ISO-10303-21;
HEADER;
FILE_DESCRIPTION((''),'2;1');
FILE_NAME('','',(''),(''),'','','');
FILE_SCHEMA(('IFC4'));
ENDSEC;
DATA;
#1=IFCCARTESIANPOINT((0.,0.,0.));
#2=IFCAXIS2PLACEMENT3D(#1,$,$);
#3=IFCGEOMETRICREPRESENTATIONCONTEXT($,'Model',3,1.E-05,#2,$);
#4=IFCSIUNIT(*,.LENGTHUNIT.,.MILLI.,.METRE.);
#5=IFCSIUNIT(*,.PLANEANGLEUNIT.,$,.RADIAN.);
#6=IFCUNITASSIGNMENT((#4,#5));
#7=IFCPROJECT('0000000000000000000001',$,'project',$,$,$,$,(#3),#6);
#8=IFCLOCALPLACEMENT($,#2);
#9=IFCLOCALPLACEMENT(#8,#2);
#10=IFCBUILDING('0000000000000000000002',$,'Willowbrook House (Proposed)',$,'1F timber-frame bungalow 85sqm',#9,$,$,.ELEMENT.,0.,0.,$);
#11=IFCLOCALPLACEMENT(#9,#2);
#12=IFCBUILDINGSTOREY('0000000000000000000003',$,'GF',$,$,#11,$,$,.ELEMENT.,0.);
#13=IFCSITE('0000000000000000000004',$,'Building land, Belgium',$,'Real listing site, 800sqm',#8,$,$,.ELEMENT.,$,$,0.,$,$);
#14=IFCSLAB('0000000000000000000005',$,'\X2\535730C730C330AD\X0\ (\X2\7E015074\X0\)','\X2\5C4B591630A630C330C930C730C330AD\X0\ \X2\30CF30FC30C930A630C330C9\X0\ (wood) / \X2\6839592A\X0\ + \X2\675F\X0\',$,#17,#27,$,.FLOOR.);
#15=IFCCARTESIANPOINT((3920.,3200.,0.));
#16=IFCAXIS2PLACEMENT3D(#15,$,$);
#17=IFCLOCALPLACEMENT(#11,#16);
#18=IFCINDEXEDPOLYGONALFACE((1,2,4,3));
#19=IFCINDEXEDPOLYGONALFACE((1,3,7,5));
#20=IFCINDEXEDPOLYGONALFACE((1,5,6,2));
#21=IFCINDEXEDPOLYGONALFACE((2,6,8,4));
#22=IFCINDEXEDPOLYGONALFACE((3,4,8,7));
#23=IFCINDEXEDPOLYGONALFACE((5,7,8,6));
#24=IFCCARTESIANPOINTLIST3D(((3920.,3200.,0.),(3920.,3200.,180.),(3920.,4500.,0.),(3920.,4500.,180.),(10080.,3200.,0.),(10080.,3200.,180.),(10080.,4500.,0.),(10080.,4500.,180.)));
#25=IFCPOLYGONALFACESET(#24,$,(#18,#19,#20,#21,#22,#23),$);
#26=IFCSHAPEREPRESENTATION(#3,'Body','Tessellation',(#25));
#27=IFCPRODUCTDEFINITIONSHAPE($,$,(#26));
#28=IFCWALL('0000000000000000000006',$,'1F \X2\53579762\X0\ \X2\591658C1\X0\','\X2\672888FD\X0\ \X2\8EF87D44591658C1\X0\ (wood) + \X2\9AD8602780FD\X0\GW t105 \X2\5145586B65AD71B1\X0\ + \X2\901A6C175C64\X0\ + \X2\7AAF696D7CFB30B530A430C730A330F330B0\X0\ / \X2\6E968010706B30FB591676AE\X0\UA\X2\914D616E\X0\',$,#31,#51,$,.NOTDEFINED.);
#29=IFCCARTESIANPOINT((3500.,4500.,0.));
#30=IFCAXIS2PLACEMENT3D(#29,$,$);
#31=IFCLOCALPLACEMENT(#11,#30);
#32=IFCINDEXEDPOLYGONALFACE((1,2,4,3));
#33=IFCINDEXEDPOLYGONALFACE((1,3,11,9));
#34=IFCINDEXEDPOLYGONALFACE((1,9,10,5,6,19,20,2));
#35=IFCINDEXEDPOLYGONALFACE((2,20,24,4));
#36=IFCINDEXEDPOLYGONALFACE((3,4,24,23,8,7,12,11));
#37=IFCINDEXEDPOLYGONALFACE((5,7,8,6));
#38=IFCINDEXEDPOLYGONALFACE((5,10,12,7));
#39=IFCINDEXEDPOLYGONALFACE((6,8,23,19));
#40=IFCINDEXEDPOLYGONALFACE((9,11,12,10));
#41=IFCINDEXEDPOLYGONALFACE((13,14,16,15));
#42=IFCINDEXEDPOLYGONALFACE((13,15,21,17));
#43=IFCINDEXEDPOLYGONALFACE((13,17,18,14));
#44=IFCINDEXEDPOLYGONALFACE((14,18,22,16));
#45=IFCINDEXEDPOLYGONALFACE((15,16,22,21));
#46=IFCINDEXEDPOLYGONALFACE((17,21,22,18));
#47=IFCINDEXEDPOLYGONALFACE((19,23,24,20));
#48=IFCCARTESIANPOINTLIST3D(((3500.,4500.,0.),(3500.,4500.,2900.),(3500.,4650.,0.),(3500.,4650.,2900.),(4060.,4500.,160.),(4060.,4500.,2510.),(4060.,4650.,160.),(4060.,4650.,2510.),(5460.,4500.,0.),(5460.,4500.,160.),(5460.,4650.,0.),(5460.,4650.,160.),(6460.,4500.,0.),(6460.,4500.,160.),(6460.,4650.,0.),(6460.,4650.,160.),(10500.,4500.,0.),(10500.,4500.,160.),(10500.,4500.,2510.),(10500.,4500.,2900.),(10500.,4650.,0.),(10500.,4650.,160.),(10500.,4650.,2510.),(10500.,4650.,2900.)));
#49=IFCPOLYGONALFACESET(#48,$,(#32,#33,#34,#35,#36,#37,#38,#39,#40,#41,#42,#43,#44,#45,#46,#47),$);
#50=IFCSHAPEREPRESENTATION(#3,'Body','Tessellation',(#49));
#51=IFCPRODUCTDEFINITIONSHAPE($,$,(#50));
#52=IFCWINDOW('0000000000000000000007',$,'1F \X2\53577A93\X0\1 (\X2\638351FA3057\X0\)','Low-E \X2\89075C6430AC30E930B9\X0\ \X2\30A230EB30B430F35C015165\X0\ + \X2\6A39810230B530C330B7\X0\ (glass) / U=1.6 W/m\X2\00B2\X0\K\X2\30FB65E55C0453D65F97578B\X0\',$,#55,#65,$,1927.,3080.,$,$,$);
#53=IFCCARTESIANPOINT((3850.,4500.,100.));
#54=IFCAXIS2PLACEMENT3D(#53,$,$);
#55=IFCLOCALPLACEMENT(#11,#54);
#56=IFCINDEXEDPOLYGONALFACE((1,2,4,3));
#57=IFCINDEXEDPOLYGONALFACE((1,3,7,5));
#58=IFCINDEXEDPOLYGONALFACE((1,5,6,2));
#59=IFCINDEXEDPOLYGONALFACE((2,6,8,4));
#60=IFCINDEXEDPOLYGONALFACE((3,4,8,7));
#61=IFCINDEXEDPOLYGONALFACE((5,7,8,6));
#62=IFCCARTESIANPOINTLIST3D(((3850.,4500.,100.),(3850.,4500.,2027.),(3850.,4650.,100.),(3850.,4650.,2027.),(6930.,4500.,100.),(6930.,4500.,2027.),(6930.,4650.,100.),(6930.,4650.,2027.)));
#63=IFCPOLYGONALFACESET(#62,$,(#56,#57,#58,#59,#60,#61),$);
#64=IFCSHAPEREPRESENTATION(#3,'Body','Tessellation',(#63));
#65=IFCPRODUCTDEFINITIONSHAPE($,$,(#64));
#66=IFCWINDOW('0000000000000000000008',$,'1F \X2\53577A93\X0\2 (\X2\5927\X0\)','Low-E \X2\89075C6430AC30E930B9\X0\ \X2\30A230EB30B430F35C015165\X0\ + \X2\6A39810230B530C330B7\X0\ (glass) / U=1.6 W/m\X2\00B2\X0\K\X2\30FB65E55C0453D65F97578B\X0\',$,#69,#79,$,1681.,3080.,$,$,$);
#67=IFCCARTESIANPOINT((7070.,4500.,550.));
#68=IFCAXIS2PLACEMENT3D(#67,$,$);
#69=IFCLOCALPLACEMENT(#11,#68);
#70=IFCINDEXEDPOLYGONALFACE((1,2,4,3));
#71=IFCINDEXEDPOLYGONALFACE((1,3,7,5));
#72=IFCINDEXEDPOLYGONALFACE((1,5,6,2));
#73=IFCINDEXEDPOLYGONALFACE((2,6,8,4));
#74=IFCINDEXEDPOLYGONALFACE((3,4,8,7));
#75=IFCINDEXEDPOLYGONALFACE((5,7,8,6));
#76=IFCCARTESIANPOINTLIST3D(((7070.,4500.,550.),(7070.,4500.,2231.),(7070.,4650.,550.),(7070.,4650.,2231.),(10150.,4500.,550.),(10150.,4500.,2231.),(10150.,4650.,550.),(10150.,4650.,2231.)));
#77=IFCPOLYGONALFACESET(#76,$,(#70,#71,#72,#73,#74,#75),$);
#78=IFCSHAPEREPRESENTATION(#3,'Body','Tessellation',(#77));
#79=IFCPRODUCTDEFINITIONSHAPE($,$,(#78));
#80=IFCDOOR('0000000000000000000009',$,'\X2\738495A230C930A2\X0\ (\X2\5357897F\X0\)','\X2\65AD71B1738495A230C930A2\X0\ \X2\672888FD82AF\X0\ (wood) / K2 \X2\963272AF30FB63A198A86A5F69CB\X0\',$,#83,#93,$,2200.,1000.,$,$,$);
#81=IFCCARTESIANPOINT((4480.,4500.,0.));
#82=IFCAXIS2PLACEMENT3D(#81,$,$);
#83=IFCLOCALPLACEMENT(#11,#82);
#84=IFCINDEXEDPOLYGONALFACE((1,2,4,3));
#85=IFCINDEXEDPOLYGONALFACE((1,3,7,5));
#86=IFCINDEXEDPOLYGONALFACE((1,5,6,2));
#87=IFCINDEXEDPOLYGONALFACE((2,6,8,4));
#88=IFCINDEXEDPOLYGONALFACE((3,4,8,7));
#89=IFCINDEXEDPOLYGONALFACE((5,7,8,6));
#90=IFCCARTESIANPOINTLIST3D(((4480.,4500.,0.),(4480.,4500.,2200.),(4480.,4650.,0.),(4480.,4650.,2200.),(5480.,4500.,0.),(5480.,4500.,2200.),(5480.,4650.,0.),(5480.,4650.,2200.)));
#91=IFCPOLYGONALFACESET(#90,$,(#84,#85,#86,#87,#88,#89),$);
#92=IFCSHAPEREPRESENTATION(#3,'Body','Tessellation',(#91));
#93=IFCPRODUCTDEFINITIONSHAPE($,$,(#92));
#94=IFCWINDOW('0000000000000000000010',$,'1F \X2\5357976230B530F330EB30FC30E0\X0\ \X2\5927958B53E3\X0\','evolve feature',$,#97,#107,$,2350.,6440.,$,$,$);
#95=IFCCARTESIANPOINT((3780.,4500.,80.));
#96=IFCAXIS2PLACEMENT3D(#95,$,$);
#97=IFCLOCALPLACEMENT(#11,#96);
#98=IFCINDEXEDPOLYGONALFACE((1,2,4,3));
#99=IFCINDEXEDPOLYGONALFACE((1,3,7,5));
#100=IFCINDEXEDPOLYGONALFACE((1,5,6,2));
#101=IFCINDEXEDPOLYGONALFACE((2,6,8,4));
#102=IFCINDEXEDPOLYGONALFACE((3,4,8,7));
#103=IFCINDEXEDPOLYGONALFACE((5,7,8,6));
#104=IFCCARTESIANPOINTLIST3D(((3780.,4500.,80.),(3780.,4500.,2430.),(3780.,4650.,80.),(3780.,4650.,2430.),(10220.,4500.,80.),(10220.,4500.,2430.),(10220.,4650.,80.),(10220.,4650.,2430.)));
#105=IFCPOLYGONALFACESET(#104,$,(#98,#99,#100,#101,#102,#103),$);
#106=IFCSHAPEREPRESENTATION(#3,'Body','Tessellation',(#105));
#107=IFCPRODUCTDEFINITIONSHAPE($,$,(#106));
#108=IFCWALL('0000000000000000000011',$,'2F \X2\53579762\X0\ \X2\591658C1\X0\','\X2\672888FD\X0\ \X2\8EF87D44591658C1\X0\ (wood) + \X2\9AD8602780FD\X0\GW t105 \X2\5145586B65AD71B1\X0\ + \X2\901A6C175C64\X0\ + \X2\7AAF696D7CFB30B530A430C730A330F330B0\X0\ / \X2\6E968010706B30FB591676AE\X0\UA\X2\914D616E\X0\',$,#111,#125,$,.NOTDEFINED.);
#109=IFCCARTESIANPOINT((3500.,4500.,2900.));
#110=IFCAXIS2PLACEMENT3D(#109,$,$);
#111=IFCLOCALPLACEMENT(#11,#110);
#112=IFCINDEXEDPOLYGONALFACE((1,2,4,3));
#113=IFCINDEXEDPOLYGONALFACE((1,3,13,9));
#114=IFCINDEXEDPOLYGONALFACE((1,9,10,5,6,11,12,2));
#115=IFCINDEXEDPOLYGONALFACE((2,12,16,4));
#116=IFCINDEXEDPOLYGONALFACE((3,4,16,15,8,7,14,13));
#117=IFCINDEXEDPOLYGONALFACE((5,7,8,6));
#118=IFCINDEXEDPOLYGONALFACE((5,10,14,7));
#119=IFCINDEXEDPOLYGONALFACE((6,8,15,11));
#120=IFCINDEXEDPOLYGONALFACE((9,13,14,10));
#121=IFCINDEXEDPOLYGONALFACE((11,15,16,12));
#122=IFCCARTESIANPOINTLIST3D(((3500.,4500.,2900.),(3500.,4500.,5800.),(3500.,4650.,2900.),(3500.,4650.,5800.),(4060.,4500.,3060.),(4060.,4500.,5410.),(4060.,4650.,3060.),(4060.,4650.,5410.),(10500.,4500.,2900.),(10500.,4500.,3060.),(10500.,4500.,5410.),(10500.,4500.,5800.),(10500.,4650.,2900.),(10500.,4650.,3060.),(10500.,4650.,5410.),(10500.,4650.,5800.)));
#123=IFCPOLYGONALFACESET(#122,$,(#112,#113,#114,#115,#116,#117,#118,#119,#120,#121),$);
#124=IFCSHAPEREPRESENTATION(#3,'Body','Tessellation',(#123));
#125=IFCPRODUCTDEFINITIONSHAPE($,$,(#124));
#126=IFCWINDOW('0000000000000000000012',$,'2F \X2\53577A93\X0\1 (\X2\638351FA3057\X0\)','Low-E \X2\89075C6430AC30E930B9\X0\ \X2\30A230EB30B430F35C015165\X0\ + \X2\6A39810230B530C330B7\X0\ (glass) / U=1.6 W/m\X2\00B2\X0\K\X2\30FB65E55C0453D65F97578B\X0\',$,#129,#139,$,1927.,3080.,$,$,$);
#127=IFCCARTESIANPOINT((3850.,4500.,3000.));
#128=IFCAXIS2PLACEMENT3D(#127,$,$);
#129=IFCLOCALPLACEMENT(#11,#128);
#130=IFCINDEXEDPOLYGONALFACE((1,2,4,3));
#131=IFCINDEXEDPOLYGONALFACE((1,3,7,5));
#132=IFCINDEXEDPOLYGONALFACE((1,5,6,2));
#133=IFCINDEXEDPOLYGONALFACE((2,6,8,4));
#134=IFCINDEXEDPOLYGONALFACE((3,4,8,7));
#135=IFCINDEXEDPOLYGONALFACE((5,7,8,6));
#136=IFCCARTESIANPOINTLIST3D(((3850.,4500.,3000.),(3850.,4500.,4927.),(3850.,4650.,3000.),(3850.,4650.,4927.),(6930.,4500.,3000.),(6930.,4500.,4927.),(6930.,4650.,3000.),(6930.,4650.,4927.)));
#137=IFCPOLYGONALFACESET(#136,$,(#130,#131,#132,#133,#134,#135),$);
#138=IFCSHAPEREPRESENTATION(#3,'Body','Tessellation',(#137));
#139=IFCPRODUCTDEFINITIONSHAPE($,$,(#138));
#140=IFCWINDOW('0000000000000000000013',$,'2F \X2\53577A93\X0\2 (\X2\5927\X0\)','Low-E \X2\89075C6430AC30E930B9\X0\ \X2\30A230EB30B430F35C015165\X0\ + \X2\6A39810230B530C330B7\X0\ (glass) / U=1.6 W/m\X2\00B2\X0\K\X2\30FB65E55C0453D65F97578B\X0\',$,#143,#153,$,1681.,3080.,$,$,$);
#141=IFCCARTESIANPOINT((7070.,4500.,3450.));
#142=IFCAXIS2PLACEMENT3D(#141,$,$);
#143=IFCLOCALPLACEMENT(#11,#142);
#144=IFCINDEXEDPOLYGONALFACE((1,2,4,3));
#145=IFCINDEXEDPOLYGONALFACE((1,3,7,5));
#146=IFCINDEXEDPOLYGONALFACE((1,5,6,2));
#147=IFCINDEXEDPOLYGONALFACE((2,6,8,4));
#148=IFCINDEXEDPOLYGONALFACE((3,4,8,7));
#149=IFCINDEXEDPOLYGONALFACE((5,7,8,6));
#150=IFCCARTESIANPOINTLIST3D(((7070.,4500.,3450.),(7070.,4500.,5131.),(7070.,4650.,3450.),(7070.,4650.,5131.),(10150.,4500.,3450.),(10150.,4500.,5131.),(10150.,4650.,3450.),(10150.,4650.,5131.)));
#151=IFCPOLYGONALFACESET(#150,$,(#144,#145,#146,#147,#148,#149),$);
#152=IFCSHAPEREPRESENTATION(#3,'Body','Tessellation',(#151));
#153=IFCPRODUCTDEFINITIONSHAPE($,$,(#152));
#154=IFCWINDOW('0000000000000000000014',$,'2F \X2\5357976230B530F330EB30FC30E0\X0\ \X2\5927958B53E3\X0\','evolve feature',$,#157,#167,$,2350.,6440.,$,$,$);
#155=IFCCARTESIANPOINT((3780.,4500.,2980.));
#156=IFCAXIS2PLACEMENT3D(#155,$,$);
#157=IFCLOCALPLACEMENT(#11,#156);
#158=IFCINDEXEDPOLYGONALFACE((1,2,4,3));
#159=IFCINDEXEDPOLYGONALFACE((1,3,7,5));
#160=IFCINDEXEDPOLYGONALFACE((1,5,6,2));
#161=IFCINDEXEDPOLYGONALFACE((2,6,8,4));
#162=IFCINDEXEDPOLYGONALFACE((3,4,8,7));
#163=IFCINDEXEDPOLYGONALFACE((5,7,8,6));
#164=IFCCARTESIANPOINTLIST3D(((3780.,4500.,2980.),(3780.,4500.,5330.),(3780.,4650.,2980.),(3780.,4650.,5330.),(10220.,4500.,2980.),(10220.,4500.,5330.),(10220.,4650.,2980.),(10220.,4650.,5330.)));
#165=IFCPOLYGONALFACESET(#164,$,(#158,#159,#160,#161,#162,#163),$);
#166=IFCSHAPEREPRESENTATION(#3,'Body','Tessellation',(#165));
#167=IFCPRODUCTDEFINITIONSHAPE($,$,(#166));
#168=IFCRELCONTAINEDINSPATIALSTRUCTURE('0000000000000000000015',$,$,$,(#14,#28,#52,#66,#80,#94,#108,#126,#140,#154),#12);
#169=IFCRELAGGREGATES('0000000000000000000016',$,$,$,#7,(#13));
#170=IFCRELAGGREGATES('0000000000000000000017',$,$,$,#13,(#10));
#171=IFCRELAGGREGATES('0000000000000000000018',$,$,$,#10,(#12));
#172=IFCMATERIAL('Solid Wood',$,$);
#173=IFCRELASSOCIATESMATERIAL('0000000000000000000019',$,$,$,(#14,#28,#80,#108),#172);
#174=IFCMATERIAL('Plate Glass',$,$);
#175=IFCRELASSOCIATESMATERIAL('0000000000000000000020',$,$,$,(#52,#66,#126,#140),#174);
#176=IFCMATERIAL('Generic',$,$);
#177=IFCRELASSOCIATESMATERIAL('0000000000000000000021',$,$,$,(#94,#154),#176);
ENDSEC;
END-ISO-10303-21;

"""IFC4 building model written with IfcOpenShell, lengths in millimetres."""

from ifc_helpers import new_model, si_unit, frame, frame_2d, origin, place, context, project, spatial, rectangle, extrude, material, element, fill, save


model = new_model("IFC4")

# Units and contexts
model_context = context("Model", 3, precision=1e-05, world=origin())
ifc_project = project(units=[si_unit("LENGTHUNIT", "METRE", prefix="MILLI"), si_unit("PLANEANGLEUNIT", "RADIAN")], contexts=[model_context])

# Site, building, storey
site_placement = place(None, origin())
site = spatial("IfcSite", under=ifc_project, at=site_placement, Name="Building land, Belgium", ObjectType="Real listing site, 800sqm", CompositionType="ELEMENT", RefElevation=0.0)
building_placement = place(site_placement, origin())
building = spatial("IfcBuilding", under=site, at=building_placement, Name="Willowbrook House (Proposed)", ObjectType="1F timber-frame bungalow 85sqm", CompositionType="ELEMENT", ElevationOfRefHeight=0.0, ElevationOfTerrain=0.0)
storey_placement = place(building_placement, origin())
storey = spatial("IfcBuildingStorey", under=building, at=storey_placement, Name="GF", CompositionType="ELEMENT", Elevation=0.0)

# Slab
ifc_material_1 = material(Name="Solid Wood")
slab_1_placement = place(storey_placement, frame((3920.0, 3200.0, 0.0)))
element("IfcSlab", 1, at=slab_1_placement, inside=storey, material=ifc_material_1, Name="南デッキ (縁側)", Description="屋外ウッドデッキ ハードウッド (wood) / 根太 + 束", PredefinedType="FLOOR", context=model_context, shape_type="SweptSolid", body=[
    extrude(rectangle(XDim=6160.0, YDim=1300.0, at=frame_2d((3080.0, 650.0))), frame((3920.0, 3200.0, 0.0)), (0.0, 0.0, 1.0), 180.0),
])
ifc_material_2 = material(Name="Generic")

# Wall, openings, windows, door
wall_1_placement = place(storey_placement, frame((3500.0, 4500.0, 0.0)))
wall_1 = element("IfcWall", 2, at=wall_1_placement, inside=storey, material=ifc_material_1, Name="1F 南面 外壁", Description="木製 軸組外壁 (wood) + 高性能GW t105 充填断熱 + 通気層 + 窯業系サイディング / 準耐火・外皮UA配慮", PredefinedType="NOTDEFINED", context=model_context, shape_type="SweptSolid", body=[
    extrude(rectangle(XDim=7000.0, YDim=150.0, at=frame_2d((3500.0, 75.0))), frame((3500.0, 4500.0, 0.0)), (0.0, 0.0, 1.0), 2900.0),
])
opening_1_placement = place(storey_placement, frame((3850.0, 4500.0, 100.0)))
opening_1 = element("IfcOpeningElement", 3, at=opening_1_placement, cuts=wall_1, PredefinedType="NOTDEFINED", context=model_context, shape_type="SweptSolid", body=[
    extrude(rectangle(XDim=3080.0, YDim=150.0, at=frame_2d((1540.0, 75.0))), frame((3850.0, 4500.0, 100.0)), (0.0, 0.0, 1.0), 1927.0),
])
opening_2_placement = place(storey_placement, frame((7070.0, 4500.0, 550.0)))
opening_2 = element("IfcOpeningElement", 4, at=opening_2_placement, cuts=wall_1, PredefinedType="NOTDEFINED", context=model_context, shape_type="SweptSolid", body=[
    extrude(rectangle(XDim=3080.0, YDim=150.0, at=frame_2d((1540.0, 75.0))), frame((7070.0, 4500.0, 550.0)), (0.0, 0.0, 1.0), 1681.0),
])
opening_3_placement = place(storey_placement, frame((4480.0, 4500.0, 0.0)))
opening_3 = element("IfcOpeningElement", 5, at=opening_3_placement, cuts=wall_1, PredefinedType="NOTDEFINED", context=model_context, shape_type="SweptSolid", body=[
    extrude(rectangle(XDim=1000.0, YDim=150.0, at=frame_2d((500.0, 75.0))), frame((4480.0, 4500.0, 0.0)), (0.0, 0.0, 1.0), 2200.0),
])
opening_4_placement = place(storey_placement, frame((3780.0, 4500.0, 80.0)))
opening_4 = element("IfcOpeningElement", 6, at=opening_4_placement, cuts=wall_1, PredefinedType="NOTDEFINED", context=model_context, shape_type="SweptSolid", body=[
    extrude(rectangle(XDim=6440.0, YDim=150.0, at=frame_2d((3220.0, 75.0))), frame((3780.0, 4500.0, 80.0)), (0.0, 0.0, 1.0), 2350.0),
])
ifc_material_3 = material(Name="Plate Glass")
window_1_placement = place(storey_placement, frame((3850.0, 4500.0, 100.0)))
window_1 = element("IfcWindow", 7, at=window_1_placement, inside=storey, material=ifc_material_3, Name="1F 南窓1 (掃出し)", Description="Low-E 複層ガラス アルゴン封入 + 樹脂サッシ (glass) / U=1.6 W/m²K・日射取得型", OverallHeight=1927.0, OverallWidth=3080.0, context=model_context, shape_type="SweptSolid", body=[
    extrude(rectangle(XDim=3080.0, YDim=150.0, at=frame_2d((1540.0, 75.0))), frame((3850.0, 4500.0, 100.0)), (0.0, 0.0, 1.0), 1927.0),
])
fill(opening_1, window_1)
window_2_placement = place(storey_placement, frame((7070.0, 4500.0, 550.0)))
window_2 = element("IfcWindow", 8, at=window_2_placement, inside=storey, material=ifc_material_3, Name="1F 南窓2 (大)", Description="Low-E 複層ガラス アルゴン封入 + 樹脂サッシ (glass) / U=1.6 W/m²K・日射取得型", OverallHeight=1681.0, OverallWidth=3080.0, context=model_context, shape_type="SweptSolid", body=[
    extrude(rectangle(XDim=3080.0, YDim=150.0, at=frame_2d((1540.0, 75.0))), frame((7070.0, 4500.0, 550.0)), (0.0, 0.0, 1.0), 1681.0),
])
fill(opening_2, window_2)
door_placement = place(storey_placement, frame((4480.0, 4500.0, 0.0)))
door = element("IfcDoor", 9, at=door_placement, inside=storey, material=ifc_material_1, Name="玄関ドア (南西)", Description="断熱玄関ドア 木製芯 (wood) / K2 防犯・採風機構", OverallHeight=2200.0, OverallWidth=1000.0, context=model_context, shape_type="SweptSolid", body=[
    extrude(rectangle(XDim=1000.0, YDim=150.0, at=frame_2d((500.0, 75.0))), frame((4480.0, 4500.0, 0.0)), (0.0, 0.0, 1.0), 2200.0),
])
fill(opening_3, door)
window_3_placement = place(storey_placement, frame((3780.0, 4500.0, 80.0)))
window_3 = element("IfcWindow", 10, at=window_3_placement, inside=storey, material=ifc_material_2, Name="1F 南面サンルーム 大開口", Description="evolve feature", OverallHeight=2350.0, OverallWidth=6440.0, context=model_context, shape_type="SweptSolid", body=[
    extrude(rectangle(XDim=6440.0, YDim=150.0, at=frame_2d((3220.0, 75.0))), frame((3780.0, 4500.0, 80.0)), (0.0, 0.0, 1.0), 2350.0),
])
fill(opening_4, window_3)

# Wall, openings, windows
wall_2_placement = place(storey_placement, frame((3500.0, 4500.0, 2900.0)))
wall_2 = element("IfcWall", 11, at=wall_2_placement, inside=storey, material=ifc_material_1, Name="2F 南面 外壁", Description="木製 軸組外壁 (wood) + 高性能GW t105 充填断熱 + 通気層 + 窯業系サイディング / 準耐火・外皮UA配慮", PredefinedType="NOTDEFINED", context=model_context, shape_type="SweptSolid", body=[
    extrude(rectangle(XDim=7000.0, YDim=150.0, at=frame_2d((3500.0, 75.0))), frame((3500.0, 4500.0, 2900.0)), (0.0, 0.0, 1.0), 2900.0),
])
opening_5_placement = place(storey_placement, frame((3850.0, 4500.0, 3000.0)))
opening_5 = element("IfcOpeningElement", 12, at=opening_5_placement, cuts=wall_2, PredefinedType="NOTDEFINED", context=model_context, shape_type="SweptSolid", body=[
    extrude(rectangle(XDim=3080.0, YDim=150.0, at=frame_2d((1540.0, 75.0))), frame((3850.0, 4500.0, 3000.0)), (0.0, 0.0, 1.0), 1927.0),
])
opening_6_placement = place(storey_placement, frame((7070.0, 4500.0, 3450.0)))
opening_6 = element("IfcOpeningElement", 13, at=opening_6_placement, cuts=wall_2, PredefinedType="NOTDEFINED", context=model_context, shape_type="SweptSolid", body=[
    extrude(rectangle(XDim=3080.0, YDim=150.0, at=frame_2d((1540.0, 75.0))), frame((7070.0, 4500.0, 3450.0)), (0.0, 0.0, 1.0), 1681.0),
])
opening_7_placement = place(storey_placement, frame((3780.0, 4500.0, 2980.0)))
opening_7 = element("IfcOpeningElement", 14, at=opening_7_placement, cuts=wall_2, PredefinedType="NOTDEFINED", context=model_context, shape_type="SweptSolid", body=[
    extrude(rectangle(XDim=6440.0, YDim=150.0, at=frame_2d((3220.0, 75.0))), frame((3780.0, 4500.0, 2980.0)), (0.0, 0.0, 1.0), 2350.0),
])
window_4_placement = place(storey_placement, frame((3850.0, 4500.0, 3000.0)))
window_4 = element("IfcWindow", 15, at=window_4_placement, inside=storey, material=ifc_material_3, Name="2F 南窓1 (掃出し)", Description="Low-E 複層ガラス アルゴン封入 + 樹脂サッシ (glass) / U=1.6 W/m²K・日射取得型", OverallHeight=1927.0, OverallWidth=3080.0, context=model_context, shape_type="SweptSolid", body=[
    extrude(rectangle(XDim=3080.0, YDim=150.0, at=frame_2d((1540.0, 75.0))), frame((3850.0, 4500.0, 3000.0)), (0.0, 0.0, 1.0), 1927.0),
])
fill(opening_5, window_4)
window_5_placement = place(storey_placement, frame((7070.0, 4500.0, 3450.0)))
window_5 = element("IfcWindow", 16, at=window_5_placement, inside=storey, material=ifc_material_3, Name="2F 南窓2 (大)", Description="Low-E 複層ガラス アルゴン封入 + 樹脂サッシ (glass) / U=1.6 W/m²K・日射取得型", OverallHeight=1681.0, OverallWidth=3080.0, context=model_context, shape_type="SweptSolid", body=[
    extrude(rectangle(XDim=3080.0, YDim=150.0, at=frame_2d((1540.0, 75.0))), frame((7070.0, 4500.0, 3450.0)), (0.0, 0.0, 1.0), 1681.0),
])
fill(opening_6, window_5)
window_6_placement = place(storey_placement, frame((3780.0, 4500.0, 2980.0)))
window_6 = element("IfcWindow", 17, at=window_6_placement, inside=storey, material=ifc_material_2, Name="2F 南面サンルーム 大開口", Description="evolve feature", OverallHeight=2350.0, OverallWidth=6440.0, context=model_context, shape_type="SweptSolid", body=[
    extrude(rectangle(XDim=6440.0, YDim=150.0, at=frame_2d((3220.0, 75.0))), frame((3780.0, 4500.0, 2980.0)), (0.0, 0.0, 1.0), 2350.0),
])
fill(opening_7, window_6)

save(model, "model.ifc")
